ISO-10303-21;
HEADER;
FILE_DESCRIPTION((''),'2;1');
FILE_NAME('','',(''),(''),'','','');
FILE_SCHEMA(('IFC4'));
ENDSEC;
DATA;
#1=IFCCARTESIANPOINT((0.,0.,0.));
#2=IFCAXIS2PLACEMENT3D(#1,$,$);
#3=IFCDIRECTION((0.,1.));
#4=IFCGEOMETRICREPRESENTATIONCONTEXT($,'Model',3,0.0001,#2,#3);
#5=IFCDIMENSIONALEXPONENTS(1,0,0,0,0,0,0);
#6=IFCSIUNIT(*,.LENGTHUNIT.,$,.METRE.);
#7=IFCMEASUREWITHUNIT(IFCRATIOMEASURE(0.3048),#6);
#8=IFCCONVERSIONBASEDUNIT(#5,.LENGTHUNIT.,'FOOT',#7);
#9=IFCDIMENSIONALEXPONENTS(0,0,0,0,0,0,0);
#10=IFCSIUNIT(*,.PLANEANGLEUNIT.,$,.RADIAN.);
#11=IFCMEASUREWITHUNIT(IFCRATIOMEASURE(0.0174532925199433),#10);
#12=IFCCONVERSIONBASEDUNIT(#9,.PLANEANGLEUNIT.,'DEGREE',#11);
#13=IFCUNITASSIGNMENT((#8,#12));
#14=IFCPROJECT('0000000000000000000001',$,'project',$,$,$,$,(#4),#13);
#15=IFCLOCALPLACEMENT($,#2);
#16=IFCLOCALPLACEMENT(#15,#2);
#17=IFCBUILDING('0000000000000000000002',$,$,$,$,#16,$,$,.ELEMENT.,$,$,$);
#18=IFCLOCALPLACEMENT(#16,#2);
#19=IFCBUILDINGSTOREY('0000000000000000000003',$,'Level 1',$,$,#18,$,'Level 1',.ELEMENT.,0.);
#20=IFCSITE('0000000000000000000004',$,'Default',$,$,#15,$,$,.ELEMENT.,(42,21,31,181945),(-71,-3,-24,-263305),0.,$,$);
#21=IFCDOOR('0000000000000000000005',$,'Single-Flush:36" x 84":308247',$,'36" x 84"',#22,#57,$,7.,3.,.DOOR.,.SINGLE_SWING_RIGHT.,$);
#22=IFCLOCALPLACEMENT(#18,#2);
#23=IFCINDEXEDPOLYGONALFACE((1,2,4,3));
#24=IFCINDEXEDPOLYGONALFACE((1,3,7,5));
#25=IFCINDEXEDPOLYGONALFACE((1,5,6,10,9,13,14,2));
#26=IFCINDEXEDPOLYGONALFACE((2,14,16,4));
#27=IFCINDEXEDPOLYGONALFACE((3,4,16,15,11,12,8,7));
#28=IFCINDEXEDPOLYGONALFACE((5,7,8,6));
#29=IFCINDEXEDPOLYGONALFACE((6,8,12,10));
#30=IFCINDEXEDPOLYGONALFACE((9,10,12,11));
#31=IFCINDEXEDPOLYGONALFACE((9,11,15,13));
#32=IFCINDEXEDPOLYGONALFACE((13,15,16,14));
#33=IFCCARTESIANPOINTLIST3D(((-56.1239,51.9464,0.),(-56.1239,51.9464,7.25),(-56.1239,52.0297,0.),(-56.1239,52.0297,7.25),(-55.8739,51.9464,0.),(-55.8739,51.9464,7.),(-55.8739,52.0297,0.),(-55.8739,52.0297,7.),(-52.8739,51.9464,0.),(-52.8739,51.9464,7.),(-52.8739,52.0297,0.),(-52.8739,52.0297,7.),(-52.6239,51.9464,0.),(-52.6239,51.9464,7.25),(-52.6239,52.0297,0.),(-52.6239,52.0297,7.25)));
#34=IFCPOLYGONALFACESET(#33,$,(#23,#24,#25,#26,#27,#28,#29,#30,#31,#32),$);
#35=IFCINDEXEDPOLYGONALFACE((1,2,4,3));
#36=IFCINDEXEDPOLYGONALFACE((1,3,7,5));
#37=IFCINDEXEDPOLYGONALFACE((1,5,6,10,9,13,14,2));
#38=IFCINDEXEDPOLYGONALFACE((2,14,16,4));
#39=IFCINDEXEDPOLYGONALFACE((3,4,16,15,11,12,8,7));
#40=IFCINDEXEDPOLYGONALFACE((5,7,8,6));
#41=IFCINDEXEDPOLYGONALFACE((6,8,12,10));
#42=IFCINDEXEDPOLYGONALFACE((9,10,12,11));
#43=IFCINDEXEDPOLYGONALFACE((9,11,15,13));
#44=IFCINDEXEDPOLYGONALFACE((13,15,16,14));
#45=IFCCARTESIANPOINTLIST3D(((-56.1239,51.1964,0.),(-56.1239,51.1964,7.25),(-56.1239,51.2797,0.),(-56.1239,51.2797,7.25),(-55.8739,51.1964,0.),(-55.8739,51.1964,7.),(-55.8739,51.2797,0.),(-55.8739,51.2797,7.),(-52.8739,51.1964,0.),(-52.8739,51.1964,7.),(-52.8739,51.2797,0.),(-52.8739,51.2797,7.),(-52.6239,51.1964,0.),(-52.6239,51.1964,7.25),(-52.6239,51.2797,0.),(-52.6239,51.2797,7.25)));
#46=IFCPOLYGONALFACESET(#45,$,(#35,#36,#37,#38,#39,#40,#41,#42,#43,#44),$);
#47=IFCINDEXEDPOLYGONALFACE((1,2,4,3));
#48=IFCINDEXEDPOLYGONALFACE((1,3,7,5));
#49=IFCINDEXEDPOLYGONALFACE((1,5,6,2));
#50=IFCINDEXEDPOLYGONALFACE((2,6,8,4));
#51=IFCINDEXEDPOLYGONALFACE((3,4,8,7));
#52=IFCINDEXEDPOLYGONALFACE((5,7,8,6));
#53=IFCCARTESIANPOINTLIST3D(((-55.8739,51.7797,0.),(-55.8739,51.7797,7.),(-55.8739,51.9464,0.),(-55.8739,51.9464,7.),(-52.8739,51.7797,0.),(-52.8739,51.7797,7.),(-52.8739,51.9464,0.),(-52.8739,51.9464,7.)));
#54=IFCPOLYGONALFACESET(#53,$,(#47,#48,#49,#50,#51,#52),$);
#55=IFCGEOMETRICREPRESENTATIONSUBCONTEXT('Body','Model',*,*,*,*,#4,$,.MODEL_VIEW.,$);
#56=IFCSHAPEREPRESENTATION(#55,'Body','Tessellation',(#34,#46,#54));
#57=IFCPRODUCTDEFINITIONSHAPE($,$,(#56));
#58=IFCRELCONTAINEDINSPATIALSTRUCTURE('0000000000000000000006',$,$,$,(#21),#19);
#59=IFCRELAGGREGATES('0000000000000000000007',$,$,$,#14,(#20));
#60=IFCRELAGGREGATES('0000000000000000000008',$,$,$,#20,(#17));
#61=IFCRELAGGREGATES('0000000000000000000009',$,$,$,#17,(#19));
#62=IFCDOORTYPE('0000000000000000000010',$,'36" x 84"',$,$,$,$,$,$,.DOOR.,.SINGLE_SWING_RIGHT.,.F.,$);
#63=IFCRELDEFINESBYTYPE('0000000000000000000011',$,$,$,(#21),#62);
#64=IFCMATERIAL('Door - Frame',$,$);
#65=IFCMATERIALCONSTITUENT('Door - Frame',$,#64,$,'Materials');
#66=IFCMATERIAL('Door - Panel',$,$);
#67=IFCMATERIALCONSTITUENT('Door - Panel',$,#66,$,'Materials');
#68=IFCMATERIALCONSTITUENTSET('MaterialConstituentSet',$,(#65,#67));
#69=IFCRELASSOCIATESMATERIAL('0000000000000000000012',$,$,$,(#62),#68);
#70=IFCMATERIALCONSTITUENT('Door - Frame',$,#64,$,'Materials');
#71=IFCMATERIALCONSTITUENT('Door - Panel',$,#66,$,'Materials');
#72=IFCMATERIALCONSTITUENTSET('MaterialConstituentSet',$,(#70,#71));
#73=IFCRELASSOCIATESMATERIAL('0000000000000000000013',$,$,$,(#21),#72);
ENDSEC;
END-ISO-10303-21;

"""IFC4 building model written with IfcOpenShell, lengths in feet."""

from ifc_helpers import new_model, entity, si_unit, converted_unit, direction, frame, frame_2d, origin, place, context, subcontext, project, spatial, polyline, rectangle, outline, extrude, source, transform, mapped, material, constituent, constituent_set, type_object, type_shapes, element, save


model = new_model("IFC4")

# Units and contexts
model_context = context("Model", 3, precision=0.0001, world=origin(), true_north=direction((0.0, 1.0)))
body_context = subcontext(model_context, "Body", "Model", "MODEL_VIEW")
ifc_project = project(units=[converted_unit("LENGTHUNIT", "FOOT", entity("IfcRatioMeasure", 0.3048), si_unit("LENGTHUNIT", "METRE"), dimensions=[1, 0, 0, 0, 0, 0, 0]), converted_unit("PLANEANGLEUNIT", "DEGREE", entity("IfcRatioMeasure", 0.0174532925199433), si_unit("PLANEANGLEUNIT", "RADIAN"), dimensions=[0, 0, 0, 0, 0, 0, 0])], contexts=[model_context])

# Site, building, storey
site_placement = place(None, origin())
site = spatial("IfcSite", under=ifc_project, at=site_placement, Name="Default", CompositionType="ELEMENT", RefLatitude=(42, 21, 31, 181945), RefLongitude=(-71, -3, -24, -263305), RefElevation=0.0)
building_placement = place(site_placement, origin())
building = spatial("IfcBuilding", under=site, at=building_placement, CompositionType="ELEMENT")
storey_placement = place(building_placement, origin())
storey = spatial("IfcBuildingStorey", under=building, at=storey_placement, Name="Level 1", LongName="Level 1", CompositionType="ELEMENT", Elevation=0.0)

# Shared definitions
placement_1 = place(storey_placement, frame((-69.2906, 51.6131, 0.0)))

# Door
ifc_material_1 = material(Name="Door - Frame")
ifc_constituent_1 = constituent(ifc_material_1, Name="Door - Frame", Category="Materials")
ifc_material_2 = material(Name="Door - Panel")
ifc_constituent_2 = constituent(ifc_material_2, Name="Door - Panel", Category="Materials")
ifc_constituent_set_1 = constituent_set(constituents=[ifc_constituent_1, ifc_constituent_2], Name="MaterialConstituentSet")
ifc_constituent_3 = constituent(ifc_material_1, Name="Door - Frame", Category="Materials")
ifc_constituent_4 = constituent(ifc_material_2, Name="Door - Panel", Category="Materials")
ifc_constituent_set_2 = constituent_set(constituents=[ifc_constituent_3, ifc_constituent_4], Name="MaterialConstituentSet")
door_type = type_object("IfcDoorType", Name="36\" x 84\"", OperationType="SINGLE_SWING_RIGHT", ParameterTakesPrecedence=False, PredefinedType="DOOR", material=ifc_constituent_set_2)
shared_shape = source(origin(), body_context, "Body", "SweptSolid", [
    extrude(outline(polyline([(-1.75, -3.6875), (1.75, -3.6875), (1.75, 3.5625), (1.5, 3.5625), (1.5, -3.4375), (-1.5, -3.4375), (-1.5, 3.5625), (-1.75, 3.5625), (-1.75, -3.6875)])), frame((1.5, 0.6667, 3.5625), z_axis=(0.0, 1.0, 0.0), x_axis=(1.0, 0.0, 0.0)), (0.0, 0.0, 1.0), 0.0833),
    extrude(outline(polyline([(-3.6875, -1.75), (3.5625, -1.75), (3.5625, -1.5), (-3.4375, -1.5), (-3.4375, 1.5), (3.5625, 1.5), (3.5625, 1.75), (-3.6875, 1.75), (-3.6875, -1.75)])), frame((1.5, -0.0833, 3.5625), z_axis=(0.0, 1.0, 0.0), x_axis=(0.0, 0.0, -1.0)), (0.0, 0.0, 1.0), 0.0833),
    extrude(rectangle(XDim=0.1667, YDim=3.0, at=frame_2d((0.0, 0.0), x_axis=(1.0, 0.0))), frame((1.5, 0.5833, 0.0), z_axis=(0.0, 0.0, 1.0), x_axis=(0.0, 1.0, 0.0)), (0.0, 0.0, 1.0), 7.0),
])
type_shapes(door_type, [shared_shape])
placement_2 = place(placement_1, frame((13.4167, -0.3333, 0.0)))
door_placement = place(placement_2, origin())
element("IfcDoor", 1, at=door_placement, inside=storey, type_object=door_type, material=ifc_constituent_set_1, Name="Single-Flush:36\" x 84\":308247", ObjectType="36\" x 84\"", OperationType="SINGLE_SWING_RIGHT", OverallHeight=7.0, OverallWidth=3.0, PredefinedType="DOOR", context=body_context, shape_type="MappedRepresentation", body=[
    mapped(shared_shape, transform((0.0, 0.0, 0.0), scale=1.0)),
])

save(model, "model.ifc")
